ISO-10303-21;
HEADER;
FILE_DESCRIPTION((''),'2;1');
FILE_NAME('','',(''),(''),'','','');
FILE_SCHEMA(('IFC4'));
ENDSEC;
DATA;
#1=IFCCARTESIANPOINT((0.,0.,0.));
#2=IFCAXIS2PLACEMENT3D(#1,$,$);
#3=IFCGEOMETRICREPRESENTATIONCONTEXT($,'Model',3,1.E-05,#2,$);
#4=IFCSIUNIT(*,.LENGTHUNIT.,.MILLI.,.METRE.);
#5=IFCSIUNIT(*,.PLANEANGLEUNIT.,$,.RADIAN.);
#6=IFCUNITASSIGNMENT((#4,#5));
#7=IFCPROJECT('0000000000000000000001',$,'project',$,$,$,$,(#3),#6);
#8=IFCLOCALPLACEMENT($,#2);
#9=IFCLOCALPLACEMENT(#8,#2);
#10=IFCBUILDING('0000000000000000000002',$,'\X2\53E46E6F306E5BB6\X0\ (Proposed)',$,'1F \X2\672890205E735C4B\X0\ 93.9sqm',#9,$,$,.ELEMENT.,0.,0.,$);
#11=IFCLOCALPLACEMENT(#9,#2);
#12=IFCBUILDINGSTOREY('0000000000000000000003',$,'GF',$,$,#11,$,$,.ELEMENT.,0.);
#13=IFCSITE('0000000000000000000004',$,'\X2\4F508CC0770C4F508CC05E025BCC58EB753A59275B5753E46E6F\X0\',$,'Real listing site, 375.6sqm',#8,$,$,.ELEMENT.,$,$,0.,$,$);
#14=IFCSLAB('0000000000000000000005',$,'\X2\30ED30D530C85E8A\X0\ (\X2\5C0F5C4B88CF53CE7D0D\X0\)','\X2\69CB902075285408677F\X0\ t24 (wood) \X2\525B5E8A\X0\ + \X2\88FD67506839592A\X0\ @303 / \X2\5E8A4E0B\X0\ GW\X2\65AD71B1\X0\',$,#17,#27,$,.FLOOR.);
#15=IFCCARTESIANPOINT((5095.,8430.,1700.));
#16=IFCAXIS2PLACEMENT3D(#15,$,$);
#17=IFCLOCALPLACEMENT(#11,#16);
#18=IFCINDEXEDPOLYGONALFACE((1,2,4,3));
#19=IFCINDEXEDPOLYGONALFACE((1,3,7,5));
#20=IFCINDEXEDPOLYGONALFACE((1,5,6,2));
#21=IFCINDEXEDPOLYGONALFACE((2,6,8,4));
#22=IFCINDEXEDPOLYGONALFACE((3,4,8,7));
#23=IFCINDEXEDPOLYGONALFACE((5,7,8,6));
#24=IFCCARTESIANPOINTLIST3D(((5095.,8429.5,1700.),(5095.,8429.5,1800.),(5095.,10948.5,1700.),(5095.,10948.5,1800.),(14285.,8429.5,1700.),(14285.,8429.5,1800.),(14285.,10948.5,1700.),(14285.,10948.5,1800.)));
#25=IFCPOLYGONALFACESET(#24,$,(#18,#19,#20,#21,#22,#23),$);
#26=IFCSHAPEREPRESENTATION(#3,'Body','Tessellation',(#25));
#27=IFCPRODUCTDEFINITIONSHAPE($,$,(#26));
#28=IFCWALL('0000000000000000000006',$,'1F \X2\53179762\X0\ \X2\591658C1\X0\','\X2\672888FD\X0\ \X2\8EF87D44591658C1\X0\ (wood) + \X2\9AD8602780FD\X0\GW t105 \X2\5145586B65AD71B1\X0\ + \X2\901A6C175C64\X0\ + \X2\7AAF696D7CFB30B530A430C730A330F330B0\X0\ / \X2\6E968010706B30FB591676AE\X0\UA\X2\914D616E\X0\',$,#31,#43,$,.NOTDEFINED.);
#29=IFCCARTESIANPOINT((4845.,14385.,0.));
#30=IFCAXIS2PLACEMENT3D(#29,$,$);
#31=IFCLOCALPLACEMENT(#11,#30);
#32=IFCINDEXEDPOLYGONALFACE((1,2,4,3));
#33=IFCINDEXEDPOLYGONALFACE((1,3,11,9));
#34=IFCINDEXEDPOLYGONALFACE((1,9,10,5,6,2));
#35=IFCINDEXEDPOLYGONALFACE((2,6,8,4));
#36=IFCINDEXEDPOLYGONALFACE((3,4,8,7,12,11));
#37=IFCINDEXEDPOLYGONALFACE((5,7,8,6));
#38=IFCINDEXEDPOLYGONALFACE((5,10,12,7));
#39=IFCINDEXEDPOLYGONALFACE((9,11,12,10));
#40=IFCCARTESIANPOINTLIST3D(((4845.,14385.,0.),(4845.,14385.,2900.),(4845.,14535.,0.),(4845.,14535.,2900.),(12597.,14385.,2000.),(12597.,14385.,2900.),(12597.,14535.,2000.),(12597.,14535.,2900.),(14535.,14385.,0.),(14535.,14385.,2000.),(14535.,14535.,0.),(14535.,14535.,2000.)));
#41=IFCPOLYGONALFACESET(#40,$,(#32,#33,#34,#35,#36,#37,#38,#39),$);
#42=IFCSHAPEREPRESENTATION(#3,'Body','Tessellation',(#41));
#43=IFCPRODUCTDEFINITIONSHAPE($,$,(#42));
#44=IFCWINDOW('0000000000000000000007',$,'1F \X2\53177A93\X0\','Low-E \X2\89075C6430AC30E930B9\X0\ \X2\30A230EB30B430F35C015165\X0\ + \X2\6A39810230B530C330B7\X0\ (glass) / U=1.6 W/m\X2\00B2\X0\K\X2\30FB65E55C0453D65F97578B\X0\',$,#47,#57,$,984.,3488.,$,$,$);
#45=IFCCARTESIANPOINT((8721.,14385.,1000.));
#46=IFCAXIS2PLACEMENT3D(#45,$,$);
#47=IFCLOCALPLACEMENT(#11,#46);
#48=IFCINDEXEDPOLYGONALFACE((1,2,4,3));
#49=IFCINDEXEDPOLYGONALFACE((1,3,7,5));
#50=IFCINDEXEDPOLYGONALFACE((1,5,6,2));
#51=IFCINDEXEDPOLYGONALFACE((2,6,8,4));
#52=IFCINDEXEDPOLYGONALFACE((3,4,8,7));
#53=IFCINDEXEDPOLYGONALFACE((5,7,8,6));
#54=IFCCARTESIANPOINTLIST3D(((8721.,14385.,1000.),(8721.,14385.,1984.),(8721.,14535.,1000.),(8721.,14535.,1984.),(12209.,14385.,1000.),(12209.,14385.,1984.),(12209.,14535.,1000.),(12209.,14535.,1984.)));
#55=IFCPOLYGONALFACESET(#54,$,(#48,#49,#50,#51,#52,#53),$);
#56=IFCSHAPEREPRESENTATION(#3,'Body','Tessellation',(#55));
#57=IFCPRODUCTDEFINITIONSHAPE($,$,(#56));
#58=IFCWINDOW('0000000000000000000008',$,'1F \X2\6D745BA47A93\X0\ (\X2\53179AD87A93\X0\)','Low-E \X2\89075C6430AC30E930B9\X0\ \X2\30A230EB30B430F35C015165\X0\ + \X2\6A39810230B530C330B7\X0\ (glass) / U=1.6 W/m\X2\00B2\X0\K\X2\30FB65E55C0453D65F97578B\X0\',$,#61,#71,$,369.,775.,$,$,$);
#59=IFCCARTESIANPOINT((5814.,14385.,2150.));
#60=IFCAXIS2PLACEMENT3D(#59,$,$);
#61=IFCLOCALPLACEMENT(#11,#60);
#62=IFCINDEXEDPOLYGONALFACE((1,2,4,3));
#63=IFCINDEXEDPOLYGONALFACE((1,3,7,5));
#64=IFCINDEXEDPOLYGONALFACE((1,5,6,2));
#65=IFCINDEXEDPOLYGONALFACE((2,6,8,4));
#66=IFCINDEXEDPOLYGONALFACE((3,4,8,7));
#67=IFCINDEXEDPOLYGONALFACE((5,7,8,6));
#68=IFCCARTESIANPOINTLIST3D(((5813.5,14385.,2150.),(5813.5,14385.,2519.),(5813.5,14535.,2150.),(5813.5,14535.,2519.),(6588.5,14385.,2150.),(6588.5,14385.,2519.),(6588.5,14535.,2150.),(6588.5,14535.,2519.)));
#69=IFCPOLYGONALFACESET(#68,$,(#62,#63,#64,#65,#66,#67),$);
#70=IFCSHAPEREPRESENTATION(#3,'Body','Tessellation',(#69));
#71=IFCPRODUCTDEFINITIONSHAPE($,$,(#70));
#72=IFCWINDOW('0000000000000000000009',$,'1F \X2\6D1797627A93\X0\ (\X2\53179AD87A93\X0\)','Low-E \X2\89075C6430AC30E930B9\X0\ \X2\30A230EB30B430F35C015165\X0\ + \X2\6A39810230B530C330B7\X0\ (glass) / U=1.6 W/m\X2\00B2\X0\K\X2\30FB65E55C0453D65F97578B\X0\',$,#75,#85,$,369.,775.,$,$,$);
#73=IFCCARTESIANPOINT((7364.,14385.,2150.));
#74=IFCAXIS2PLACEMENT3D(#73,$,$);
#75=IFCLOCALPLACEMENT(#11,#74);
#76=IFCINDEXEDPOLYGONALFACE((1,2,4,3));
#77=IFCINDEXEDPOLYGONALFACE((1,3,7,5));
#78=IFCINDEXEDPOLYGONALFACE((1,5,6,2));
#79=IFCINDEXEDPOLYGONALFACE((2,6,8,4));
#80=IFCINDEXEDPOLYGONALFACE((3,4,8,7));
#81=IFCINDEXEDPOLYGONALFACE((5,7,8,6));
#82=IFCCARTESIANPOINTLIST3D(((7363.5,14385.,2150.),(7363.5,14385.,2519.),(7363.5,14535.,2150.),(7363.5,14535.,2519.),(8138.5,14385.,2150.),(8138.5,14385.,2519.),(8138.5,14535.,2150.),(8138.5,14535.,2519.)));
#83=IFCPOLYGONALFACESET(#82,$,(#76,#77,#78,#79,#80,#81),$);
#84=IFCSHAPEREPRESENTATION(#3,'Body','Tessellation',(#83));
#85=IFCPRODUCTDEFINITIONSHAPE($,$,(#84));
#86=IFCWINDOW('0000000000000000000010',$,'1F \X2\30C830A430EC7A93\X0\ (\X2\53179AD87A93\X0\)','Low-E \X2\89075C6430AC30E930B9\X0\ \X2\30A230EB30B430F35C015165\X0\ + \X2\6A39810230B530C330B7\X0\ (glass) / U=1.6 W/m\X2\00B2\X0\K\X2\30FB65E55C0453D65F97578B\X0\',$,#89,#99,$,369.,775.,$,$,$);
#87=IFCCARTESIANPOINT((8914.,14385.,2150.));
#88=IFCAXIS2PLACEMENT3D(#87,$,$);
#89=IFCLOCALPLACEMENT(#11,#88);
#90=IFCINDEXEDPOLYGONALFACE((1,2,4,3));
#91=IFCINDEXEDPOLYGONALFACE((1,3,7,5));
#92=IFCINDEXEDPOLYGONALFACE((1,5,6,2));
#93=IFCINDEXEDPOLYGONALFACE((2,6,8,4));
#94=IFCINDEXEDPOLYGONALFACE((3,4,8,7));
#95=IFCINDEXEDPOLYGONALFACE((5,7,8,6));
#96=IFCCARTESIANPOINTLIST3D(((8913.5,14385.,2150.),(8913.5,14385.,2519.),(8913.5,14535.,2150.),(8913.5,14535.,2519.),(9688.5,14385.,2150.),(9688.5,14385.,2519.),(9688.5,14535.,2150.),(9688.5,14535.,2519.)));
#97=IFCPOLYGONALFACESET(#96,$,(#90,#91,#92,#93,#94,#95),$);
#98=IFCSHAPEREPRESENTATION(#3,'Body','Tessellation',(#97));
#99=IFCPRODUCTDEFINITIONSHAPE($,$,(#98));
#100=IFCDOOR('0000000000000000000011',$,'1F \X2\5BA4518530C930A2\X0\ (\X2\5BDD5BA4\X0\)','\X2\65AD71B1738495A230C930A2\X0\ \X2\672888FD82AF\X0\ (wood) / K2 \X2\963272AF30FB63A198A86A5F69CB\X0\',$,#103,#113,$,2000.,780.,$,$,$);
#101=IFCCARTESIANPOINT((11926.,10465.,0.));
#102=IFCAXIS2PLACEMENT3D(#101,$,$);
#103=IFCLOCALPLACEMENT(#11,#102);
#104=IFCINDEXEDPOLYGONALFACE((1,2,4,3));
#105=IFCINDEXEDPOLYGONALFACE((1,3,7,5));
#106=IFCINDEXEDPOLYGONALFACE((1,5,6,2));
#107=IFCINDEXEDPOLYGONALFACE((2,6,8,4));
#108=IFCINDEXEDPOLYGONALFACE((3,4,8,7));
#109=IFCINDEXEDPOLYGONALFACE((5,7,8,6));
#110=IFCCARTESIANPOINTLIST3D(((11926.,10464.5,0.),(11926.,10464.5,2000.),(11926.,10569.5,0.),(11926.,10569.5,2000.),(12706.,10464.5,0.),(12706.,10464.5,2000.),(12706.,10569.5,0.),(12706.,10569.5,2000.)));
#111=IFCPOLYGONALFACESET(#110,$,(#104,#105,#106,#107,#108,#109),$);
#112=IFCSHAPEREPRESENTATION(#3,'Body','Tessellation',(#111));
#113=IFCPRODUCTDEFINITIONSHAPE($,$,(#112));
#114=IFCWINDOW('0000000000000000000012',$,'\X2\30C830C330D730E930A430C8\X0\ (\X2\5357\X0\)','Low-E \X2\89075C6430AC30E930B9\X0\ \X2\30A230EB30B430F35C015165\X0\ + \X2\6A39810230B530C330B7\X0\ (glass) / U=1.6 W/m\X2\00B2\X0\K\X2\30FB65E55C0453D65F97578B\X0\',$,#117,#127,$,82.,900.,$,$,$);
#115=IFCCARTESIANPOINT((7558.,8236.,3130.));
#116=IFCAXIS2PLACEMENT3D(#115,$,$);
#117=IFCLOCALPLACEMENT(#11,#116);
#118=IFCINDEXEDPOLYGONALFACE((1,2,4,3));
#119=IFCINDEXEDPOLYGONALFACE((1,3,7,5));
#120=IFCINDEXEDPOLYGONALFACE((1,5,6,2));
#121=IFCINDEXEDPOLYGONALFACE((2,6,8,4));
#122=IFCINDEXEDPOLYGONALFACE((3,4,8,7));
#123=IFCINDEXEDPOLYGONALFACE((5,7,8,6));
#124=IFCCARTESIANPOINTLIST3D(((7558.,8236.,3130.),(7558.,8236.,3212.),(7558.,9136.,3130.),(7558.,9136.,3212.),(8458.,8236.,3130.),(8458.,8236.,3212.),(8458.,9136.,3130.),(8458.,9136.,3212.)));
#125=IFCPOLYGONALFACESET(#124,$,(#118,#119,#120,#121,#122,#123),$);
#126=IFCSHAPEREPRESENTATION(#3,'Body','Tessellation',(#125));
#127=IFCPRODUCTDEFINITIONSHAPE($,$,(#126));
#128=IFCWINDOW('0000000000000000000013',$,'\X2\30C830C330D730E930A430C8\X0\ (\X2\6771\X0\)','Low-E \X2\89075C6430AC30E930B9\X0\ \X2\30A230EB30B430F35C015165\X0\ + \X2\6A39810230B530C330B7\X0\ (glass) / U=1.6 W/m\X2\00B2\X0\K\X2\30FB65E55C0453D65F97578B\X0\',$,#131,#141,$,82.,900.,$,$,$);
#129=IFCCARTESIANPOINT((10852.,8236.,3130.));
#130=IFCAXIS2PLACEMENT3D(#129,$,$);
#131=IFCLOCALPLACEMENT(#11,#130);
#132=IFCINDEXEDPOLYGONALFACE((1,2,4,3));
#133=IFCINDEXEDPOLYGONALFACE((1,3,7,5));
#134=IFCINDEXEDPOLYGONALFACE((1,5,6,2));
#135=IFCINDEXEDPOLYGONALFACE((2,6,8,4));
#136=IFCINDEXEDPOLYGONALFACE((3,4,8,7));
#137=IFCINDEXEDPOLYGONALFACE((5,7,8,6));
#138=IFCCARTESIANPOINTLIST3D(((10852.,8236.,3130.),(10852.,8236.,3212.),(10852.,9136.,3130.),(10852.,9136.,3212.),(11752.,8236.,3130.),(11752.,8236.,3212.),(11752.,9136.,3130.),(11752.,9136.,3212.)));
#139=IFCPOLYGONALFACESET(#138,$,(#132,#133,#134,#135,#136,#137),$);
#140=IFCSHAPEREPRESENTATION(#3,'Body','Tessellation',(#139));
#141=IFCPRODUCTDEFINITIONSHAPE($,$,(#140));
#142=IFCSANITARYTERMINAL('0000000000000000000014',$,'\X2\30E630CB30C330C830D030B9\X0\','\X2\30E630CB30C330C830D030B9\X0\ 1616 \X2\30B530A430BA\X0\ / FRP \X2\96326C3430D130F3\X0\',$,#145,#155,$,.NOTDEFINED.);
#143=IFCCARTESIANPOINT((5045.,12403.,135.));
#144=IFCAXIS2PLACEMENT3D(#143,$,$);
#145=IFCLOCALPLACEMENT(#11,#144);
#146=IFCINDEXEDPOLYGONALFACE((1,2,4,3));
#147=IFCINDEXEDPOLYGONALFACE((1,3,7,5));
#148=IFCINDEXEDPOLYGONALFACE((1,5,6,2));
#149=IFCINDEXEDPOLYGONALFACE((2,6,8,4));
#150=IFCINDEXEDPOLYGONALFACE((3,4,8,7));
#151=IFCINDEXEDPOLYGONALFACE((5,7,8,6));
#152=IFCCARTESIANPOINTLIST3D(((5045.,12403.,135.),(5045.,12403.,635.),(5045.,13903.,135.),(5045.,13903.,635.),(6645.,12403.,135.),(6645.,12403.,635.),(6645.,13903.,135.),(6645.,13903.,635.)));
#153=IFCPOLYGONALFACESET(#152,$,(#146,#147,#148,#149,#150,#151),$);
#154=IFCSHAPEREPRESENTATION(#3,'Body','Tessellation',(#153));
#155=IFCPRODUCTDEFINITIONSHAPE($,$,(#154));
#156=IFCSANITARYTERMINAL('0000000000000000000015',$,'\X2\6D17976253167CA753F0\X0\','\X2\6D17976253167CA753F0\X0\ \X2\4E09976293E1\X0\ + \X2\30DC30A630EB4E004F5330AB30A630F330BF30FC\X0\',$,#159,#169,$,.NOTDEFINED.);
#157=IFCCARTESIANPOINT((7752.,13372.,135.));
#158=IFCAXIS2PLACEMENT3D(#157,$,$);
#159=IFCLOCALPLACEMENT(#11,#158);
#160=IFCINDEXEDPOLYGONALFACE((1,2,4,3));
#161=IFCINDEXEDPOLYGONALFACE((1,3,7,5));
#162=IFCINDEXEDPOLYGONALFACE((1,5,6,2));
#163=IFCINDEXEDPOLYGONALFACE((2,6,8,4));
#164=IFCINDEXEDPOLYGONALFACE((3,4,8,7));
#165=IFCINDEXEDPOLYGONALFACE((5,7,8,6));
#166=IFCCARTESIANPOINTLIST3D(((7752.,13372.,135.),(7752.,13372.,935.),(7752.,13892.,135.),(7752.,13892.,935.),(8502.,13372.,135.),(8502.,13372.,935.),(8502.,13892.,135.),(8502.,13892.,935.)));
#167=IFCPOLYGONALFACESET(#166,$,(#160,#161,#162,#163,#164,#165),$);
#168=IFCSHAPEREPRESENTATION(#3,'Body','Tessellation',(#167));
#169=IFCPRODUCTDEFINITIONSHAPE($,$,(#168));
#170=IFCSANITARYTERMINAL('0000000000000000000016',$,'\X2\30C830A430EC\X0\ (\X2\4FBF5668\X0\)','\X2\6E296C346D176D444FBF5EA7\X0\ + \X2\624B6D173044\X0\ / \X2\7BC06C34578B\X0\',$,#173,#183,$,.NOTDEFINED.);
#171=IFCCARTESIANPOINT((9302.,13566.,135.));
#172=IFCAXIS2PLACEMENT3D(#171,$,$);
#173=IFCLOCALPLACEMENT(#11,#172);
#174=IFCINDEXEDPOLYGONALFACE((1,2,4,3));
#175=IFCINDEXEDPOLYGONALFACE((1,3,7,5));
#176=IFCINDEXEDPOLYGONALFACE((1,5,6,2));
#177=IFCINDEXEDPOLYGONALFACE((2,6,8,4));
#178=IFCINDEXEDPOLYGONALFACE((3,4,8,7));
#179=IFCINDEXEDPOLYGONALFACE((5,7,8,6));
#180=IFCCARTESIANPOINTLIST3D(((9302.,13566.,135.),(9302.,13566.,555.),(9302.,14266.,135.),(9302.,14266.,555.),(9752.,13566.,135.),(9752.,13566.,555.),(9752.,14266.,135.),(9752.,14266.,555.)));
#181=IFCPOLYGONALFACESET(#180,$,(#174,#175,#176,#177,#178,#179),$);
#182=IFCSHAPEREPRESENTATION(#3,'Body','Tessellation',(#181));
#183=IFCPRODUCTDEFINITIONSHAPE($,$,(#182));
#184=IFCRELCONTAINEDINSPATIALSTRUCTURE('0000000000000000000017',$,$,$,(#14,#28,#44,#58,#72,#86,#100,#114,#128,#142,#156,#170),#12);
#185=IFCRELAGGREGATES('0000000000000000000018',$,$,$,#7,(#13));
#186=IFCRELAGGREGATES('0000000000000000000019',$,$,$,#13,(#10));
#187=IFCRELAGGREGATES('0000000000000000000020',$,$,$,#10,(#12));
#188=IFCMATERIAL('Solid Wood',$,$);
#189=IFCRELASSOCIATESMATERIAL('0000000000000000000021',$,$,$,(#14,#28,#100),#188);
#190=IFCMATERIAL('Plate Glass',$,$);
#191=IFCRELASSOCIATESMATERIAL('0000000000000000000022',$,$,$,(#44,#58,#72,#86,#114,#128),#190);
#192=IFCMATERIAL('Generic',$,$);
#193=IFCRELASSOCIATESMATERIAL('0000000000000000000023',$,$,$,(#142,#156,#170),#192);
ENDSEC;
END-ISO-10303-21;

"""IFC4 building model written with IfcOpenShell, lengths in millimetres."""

from ifc_helpers import new_model, si_unit, frame, frame_2d, origin, place, context, project, spatial, rectangle, extrude, material, element, fill, save


model = new_model("IFC4")

# Units and contexts
model_context = context("Model", 3, precision=1e-05, world=origin())
ifc_project = project(units=[si_unit("LENGTHUNIT", "METRE", prefix="MILLI"), si_unit("PLANEANGLEUNIT", "RADIAN")], contexts=[model_context])

# Site, building, storey
site_placement = place(None, origin())
site = spatial("IfcSite", under=ifc_project, at=site_placement, Name="佐賀県佐賀市富士町大字古湯", ObjectType="Real listing site, 375.6sqm", CompositionType="ELEMENT", RefElevation=0.0)
building_placement = place(site_placement, origin())
building = spatial("IfcBuilding", under=site, at=building_placement, Name="古湯の家 (Proposed)", ObjectType="1F 木造平屋 93.9sqm", CompositionType="ELEMENT", ElevationOfRefHeight=0.0, ElevationOfTerrain=0.0)
storey_placement = place(building_placement, origin())
storey = spatial("IfcBuildingStorey", under=building, at=storey_placement, Name="GF", CompositionType="ELEMENT", Elevation=0.0)

# Slab
ifc_material_1 = material(Name="Solid Wood")
slab_placement = place(storey_placement, frame((5095.0, 8430.0, 1700.0)))
element("IfcSlab", 1, at=slab_placement, inside=storey, material=ifc_material_1, Name="ロフト床 (小屋裏収納)", Description="構造用合板 t24 (wood) 剛床 + 製材根太 @303 / 床下 GW断熱", PredefinedType="FLOOR", context=model_context, shape_type="SweptSolid", body=[
    extrude(rectangle(XDim=9190.0, YDim=2519.0, at=frame_2d((4595.0, 1259.0))), frame((5095.0, 8430.0, 1700.0)), (0.0, 0.0, 1.0), 100.0),
])

# Wall, openings, windows
wall_1_placement = place(storey_placement, frame((4845.0, 14385.0, 0.0)))
wall_1 = element("IfcWall", 2, at=wall_1_placement, inside=storey, material=ifc_material_1, Name="1F 北面 外壁", Description="木製 軸組外壁 (wood) + 高性能GW t105 充填断熱 + 通気層 + 窯業系サイディング / 準耐火・外皮UA配慮", PredefinedType="NOTDEFINED", context=model_context, shape_type="SweptSolid", body=[
    extrude(rectangle(XDim=9690.0, YDim=150.0, at=frame_2d((4845.0, 75.0))), frame((4845.0, 14385.0, 0.0)), (0.0, 0.0, 1.0), 2900.0),
])
opening_1_placement = place(storey_placement, frame((8721.0, 14385.0, 1000.0)))
opening_1 = element("IfcOpeningElement", 3, at=opening_1_placement, cuts=wall_1, PredefinedType="NOTDEFINED", context=model_context, shape_type="SweptSolid", body=[
    extrude(rectangle(XDim=3488.0, YDim=150.0, at=frame_2d((1744.0, 75.0))), frame((8721.0, 14385.0, 1000.0)), (0.0, 0.0, 1.0), 984.0),
])
opening_2_placement = place(storey_placement, frame((5814.0, 14385.0, 2150.0)))
opening_2 = element("IfcOpeningElement", 4, at=opening_2_placement, cuts=wall_1, PredefinedType="NOTDEFINED", context=model_context, shape_type="SweptSolid", body=[
    extrude(rectangle(XDim=775.0, YDim=150.0, at=frame_2d((387.0, 75.0))), frame((5814.0, 14385.0, 2150.0)), (0.0, 0.0, 1.0), 369.0),
])
opening_3_placement = place(storey_placement, frame((7364.0, 14385.0, 2150.0)))
opening_3 = element("IfcOpeningElement", 5, at=opening_3_placement, cuts=wall_1, PredefinedType="NOTDEFINED", context=model_context, shape_type="SweptSolid", body=[
    extrude(rectangle(XDim=775.0, YDim=150.0, at=frame_2d((387.0, 75.0))), frame((7364.0, 14385.0, 2150.0)), (0.0, 0.0, 1.0), 369.0),
])
opening_4_placement = place(storey_placement, frame((8914.0, 14385.0, 2150.0)))
opening_4 = element("IfcOpeningElement", 6, at=opening_4_placement, cuts=wall_1, PredefinedType="NOTDEFINED", context=model_context, shape_type="SweptSolid", body=[
    extrude(rectangle(XDim=775.0, YDim=150.0, at=frame_2d((387.0, 75.0))), frame((8914.0, 14385.0, 2150.0)), (0.0, 0.0, 1.0), 369.0),
])
ifc_material_2 = material(Name="Plate Glass")
window_1_placement = place(storey_placement, frame((8721.0, 14385.0, 1000.0)))
window_1 = element("IfcWindow", 7, at=window_1_placement, inside=storey, material=ifc_material_2, Name="1F 北窓", Description="Low-E 複層ガラス アルゴン封入 + 樹脂サッシ (glass) / U=1.6 W/m²K・日射取得型", OverallHeight=984.0, OverallWidth=3488.0, context=model_context, shape_type="SweptSolid", body=[
    extrude(rectangle(XDim=3488.0, YDim=150.0, at=frame_2d((1744.0, 75.0))), frame((8721.0, 14385.0, 1000.0)), (0.0, 0.0, 1.0), 984.0),
])
fill(opening_1, window_1)
window_2_placement = place(storey_placement, frame((5814.0, 14385.0, 2150.0)))
window_2 = element("IfcWindow", 8, at=window_2_placement, inside=storey, material=ifc_material_2, Name="1F 浴室窓 (北高窓)", Description="Low-E 複層ガラス アルゴン封入 + 樹脂サッシ (glass) / U=1.6 W/m²K・日射取得型", OverallHeight=369.0, OverallWidth=775.0, context=model_context, shape_type="SweptSolid", body=[
    extrude(rectangle(XDim=775.0, YDim=150.0, at=frame_2d((387.0, 75.0))), frame((5814.0, 14385.0, 2150.0)), (0.0, 0.0, 1.0), 369.0),
])
fill(opening_2, window_2)
window_3_placement = place(storey_placement, frame((7364.0, 14385.0, 2150.0)))
window_3 = element("IfcWindow", 9, at=window_3_placement, inside=storey, material=ifc_material_2, Name="1F 洗面窓 (北高窓)", Description="Low-E 複層ガラス アルゴン封入 + 樹脂サッシ (glass) / U=1.6 W/m²K・日射取得型", OverallHeight=369.0, OverallWidth=775.0, context=model_context, shape_type="SweptSolid", body=[
    extrude(rectangle(XDim=775.0, YDim=150.0, at=frame_2d((387.0, 75.0))), frame((7364.0, 14385.0, 2150.0)), (0.0, 0.0, 1.0), 369.0),
])
fill(opening_3, window_3)
window_4_placement = place(storey_placement, frame((8914.0, 14385.0, 2150.0)))
window_4 = element("IfcWindow", 10, at=window_4_placement, inside=storey, material=ifc_material_2, Name="1F トイレ窓 (北高窓)", Description="Low-E 複層ガラス アルゴン封入 + 樹脂サッシ (glass) / U=1.6 W/m²K・日射取得型", OverallHeight=369.0, OverallWidth=775.0, context=model_context, shape_type="SweptSolid", body=[
    extrude(rectangle(XDim=775.0, YDim=150.0, at=frame_2d((387.0, 75.0))), frame((8914.0, 14385.0, 2150.0)), (0.0, 0.0, 1.0), 369.0),
])
fill(opening_4, window_4)

# Door
door_1_placement = place(storey_placement, frame((11926.0, 10465.0, 0.0)))
element("IfcDoor", 11, at=door_1_placement, inside=storey, material=ifc_material_1, Name="1F 室内ドア (寝室)", Description="断熱玄関ドア 木製芯 (wood) / K2 防犯・採風機構", OverallHeight=2000.0, OverallWidth=780.0, context=model_context, shape_type="SweptSolid", body=[
    extrude(rectangle(XDim=780.0, YDim=105.0, at=frame_2d((390.0, 52.0))), frame((11926.0, 10465.0, 0.0)), (0.0, 0.0, 1.0), 2000.0),
])

# Windows
window_5_placement = place(storey_placement, frame((7558.0, 8236.0, 3130.0)))
element("IfcWindow", 12, at=window_5_placement, inside=storey, material=ifc_material_2, Name="トップライト (南)", Description="Low-E 複層ガラス アルゴン封入 + 樹脂サッシ (glass) / U=1.6 W/m²K・日射取得型", OverallHeight=82.0, OverallWidth=900.0, context=model_context, shape_type="SweptSolid", body=[
    extrude(rectangle(XDim=900.0, YDim=900.0, at=frame_2d((450.0, 450.0))), frame((7558.0, 8236.0, 3130.0)), (0.0, 0.0, 1.0), 82.0),
])
window_6_placement = place(storey_placement, frame((10852.0, 8236.0, 3130.0)))
element("IfcWindow", 13, at=window_6_placement, inside=storey, material=ifc_material_2, Name="トップライト (東)", Description="Low-E 複層ガラス アルゴン封入 + 樹脂サッシ (glass) / U=1.6 W/m²K・日射取得型", OverallHeight=82.0, OverallWidth=900.0, context=model_context, shape_type="SweptSolid", body=[
    extrude(rectangle(XDim=900.0, YDim=900.0, at=frame_2d((450.0, 450.0))), frame((10852.0, 8236.0, 3130.0)), (0.0, 0.0, 1.0), 82.0),
])

# Sanitary terminals
ifc_material_3 = material(Name="Generic")
sanitary_terminal_1_placement = place(storey_placement, frame((5045.0, 12403.0, 135.0)))
element("IfcSanitaryTerminal", 14, at=sanitary_terminal_1_placement, inside=storey, material=ifc_material_3, Name="ユニットバス", Description="ユニットバス 1616 サイズ / FRP 防水パン", PredefinedType="NOTDEFINED", context=model_context, shape_type="SweptSolid", body=[
    extrude(rectangle(XDim=1600.0, YDim=1500.0, at=frame_2d((800.0, 750.0))), frame((5045.0, 12403.0, 135.0)), (0.0, 0.0, 1.0), 500.0),
])
sanitary_terminal_2_placement = place(storey_placement, frame((7752.0, 13372.0, 135.0)))
element("IfcSanitaryTerminal", 15, at=sanitary_terminal_2_placement, inside=storey, material=ifc_material_3, Name="洗面化粧台", Description="洗面化粧台 三面鏡 + ボウル一体カウンター", PredefinedType="NOTDEFINED", context=model_context, shape_type="SweptSolid", body=[
    extrude(rectangle(XDim=750.0, YDim=520.0, at=frame_2d((375.0, 260.0))), frame((7752.0, 13372.0, 135.0)), (0.0, 0.0, 1.0), 800.0),
])
sanitary_terminal_3_placement = place(storey_placement, frame((9302.0, 13566.0, 135.0)))
element("IfcSanitaryTerminal", 16, at=sanitary_terminal_3_placement, inside=storey, material=ifc_material_3, Name="トイレ (便器)", Description="温水洗浄便座 + 手洗い / 節水型", PredefinedType="NOTDEFINED", context=model_context, shape_type="SweptSolid", body=[
    extrude(rectangle(XDim=450.0, YDim=700.0, at=frame_2d((225.0, 350.0))), frame((9302.0, 13566.0, 135.0)), (0.0, 0.0, 1.0), 420.0),
])

save(model, "model.ifc")
